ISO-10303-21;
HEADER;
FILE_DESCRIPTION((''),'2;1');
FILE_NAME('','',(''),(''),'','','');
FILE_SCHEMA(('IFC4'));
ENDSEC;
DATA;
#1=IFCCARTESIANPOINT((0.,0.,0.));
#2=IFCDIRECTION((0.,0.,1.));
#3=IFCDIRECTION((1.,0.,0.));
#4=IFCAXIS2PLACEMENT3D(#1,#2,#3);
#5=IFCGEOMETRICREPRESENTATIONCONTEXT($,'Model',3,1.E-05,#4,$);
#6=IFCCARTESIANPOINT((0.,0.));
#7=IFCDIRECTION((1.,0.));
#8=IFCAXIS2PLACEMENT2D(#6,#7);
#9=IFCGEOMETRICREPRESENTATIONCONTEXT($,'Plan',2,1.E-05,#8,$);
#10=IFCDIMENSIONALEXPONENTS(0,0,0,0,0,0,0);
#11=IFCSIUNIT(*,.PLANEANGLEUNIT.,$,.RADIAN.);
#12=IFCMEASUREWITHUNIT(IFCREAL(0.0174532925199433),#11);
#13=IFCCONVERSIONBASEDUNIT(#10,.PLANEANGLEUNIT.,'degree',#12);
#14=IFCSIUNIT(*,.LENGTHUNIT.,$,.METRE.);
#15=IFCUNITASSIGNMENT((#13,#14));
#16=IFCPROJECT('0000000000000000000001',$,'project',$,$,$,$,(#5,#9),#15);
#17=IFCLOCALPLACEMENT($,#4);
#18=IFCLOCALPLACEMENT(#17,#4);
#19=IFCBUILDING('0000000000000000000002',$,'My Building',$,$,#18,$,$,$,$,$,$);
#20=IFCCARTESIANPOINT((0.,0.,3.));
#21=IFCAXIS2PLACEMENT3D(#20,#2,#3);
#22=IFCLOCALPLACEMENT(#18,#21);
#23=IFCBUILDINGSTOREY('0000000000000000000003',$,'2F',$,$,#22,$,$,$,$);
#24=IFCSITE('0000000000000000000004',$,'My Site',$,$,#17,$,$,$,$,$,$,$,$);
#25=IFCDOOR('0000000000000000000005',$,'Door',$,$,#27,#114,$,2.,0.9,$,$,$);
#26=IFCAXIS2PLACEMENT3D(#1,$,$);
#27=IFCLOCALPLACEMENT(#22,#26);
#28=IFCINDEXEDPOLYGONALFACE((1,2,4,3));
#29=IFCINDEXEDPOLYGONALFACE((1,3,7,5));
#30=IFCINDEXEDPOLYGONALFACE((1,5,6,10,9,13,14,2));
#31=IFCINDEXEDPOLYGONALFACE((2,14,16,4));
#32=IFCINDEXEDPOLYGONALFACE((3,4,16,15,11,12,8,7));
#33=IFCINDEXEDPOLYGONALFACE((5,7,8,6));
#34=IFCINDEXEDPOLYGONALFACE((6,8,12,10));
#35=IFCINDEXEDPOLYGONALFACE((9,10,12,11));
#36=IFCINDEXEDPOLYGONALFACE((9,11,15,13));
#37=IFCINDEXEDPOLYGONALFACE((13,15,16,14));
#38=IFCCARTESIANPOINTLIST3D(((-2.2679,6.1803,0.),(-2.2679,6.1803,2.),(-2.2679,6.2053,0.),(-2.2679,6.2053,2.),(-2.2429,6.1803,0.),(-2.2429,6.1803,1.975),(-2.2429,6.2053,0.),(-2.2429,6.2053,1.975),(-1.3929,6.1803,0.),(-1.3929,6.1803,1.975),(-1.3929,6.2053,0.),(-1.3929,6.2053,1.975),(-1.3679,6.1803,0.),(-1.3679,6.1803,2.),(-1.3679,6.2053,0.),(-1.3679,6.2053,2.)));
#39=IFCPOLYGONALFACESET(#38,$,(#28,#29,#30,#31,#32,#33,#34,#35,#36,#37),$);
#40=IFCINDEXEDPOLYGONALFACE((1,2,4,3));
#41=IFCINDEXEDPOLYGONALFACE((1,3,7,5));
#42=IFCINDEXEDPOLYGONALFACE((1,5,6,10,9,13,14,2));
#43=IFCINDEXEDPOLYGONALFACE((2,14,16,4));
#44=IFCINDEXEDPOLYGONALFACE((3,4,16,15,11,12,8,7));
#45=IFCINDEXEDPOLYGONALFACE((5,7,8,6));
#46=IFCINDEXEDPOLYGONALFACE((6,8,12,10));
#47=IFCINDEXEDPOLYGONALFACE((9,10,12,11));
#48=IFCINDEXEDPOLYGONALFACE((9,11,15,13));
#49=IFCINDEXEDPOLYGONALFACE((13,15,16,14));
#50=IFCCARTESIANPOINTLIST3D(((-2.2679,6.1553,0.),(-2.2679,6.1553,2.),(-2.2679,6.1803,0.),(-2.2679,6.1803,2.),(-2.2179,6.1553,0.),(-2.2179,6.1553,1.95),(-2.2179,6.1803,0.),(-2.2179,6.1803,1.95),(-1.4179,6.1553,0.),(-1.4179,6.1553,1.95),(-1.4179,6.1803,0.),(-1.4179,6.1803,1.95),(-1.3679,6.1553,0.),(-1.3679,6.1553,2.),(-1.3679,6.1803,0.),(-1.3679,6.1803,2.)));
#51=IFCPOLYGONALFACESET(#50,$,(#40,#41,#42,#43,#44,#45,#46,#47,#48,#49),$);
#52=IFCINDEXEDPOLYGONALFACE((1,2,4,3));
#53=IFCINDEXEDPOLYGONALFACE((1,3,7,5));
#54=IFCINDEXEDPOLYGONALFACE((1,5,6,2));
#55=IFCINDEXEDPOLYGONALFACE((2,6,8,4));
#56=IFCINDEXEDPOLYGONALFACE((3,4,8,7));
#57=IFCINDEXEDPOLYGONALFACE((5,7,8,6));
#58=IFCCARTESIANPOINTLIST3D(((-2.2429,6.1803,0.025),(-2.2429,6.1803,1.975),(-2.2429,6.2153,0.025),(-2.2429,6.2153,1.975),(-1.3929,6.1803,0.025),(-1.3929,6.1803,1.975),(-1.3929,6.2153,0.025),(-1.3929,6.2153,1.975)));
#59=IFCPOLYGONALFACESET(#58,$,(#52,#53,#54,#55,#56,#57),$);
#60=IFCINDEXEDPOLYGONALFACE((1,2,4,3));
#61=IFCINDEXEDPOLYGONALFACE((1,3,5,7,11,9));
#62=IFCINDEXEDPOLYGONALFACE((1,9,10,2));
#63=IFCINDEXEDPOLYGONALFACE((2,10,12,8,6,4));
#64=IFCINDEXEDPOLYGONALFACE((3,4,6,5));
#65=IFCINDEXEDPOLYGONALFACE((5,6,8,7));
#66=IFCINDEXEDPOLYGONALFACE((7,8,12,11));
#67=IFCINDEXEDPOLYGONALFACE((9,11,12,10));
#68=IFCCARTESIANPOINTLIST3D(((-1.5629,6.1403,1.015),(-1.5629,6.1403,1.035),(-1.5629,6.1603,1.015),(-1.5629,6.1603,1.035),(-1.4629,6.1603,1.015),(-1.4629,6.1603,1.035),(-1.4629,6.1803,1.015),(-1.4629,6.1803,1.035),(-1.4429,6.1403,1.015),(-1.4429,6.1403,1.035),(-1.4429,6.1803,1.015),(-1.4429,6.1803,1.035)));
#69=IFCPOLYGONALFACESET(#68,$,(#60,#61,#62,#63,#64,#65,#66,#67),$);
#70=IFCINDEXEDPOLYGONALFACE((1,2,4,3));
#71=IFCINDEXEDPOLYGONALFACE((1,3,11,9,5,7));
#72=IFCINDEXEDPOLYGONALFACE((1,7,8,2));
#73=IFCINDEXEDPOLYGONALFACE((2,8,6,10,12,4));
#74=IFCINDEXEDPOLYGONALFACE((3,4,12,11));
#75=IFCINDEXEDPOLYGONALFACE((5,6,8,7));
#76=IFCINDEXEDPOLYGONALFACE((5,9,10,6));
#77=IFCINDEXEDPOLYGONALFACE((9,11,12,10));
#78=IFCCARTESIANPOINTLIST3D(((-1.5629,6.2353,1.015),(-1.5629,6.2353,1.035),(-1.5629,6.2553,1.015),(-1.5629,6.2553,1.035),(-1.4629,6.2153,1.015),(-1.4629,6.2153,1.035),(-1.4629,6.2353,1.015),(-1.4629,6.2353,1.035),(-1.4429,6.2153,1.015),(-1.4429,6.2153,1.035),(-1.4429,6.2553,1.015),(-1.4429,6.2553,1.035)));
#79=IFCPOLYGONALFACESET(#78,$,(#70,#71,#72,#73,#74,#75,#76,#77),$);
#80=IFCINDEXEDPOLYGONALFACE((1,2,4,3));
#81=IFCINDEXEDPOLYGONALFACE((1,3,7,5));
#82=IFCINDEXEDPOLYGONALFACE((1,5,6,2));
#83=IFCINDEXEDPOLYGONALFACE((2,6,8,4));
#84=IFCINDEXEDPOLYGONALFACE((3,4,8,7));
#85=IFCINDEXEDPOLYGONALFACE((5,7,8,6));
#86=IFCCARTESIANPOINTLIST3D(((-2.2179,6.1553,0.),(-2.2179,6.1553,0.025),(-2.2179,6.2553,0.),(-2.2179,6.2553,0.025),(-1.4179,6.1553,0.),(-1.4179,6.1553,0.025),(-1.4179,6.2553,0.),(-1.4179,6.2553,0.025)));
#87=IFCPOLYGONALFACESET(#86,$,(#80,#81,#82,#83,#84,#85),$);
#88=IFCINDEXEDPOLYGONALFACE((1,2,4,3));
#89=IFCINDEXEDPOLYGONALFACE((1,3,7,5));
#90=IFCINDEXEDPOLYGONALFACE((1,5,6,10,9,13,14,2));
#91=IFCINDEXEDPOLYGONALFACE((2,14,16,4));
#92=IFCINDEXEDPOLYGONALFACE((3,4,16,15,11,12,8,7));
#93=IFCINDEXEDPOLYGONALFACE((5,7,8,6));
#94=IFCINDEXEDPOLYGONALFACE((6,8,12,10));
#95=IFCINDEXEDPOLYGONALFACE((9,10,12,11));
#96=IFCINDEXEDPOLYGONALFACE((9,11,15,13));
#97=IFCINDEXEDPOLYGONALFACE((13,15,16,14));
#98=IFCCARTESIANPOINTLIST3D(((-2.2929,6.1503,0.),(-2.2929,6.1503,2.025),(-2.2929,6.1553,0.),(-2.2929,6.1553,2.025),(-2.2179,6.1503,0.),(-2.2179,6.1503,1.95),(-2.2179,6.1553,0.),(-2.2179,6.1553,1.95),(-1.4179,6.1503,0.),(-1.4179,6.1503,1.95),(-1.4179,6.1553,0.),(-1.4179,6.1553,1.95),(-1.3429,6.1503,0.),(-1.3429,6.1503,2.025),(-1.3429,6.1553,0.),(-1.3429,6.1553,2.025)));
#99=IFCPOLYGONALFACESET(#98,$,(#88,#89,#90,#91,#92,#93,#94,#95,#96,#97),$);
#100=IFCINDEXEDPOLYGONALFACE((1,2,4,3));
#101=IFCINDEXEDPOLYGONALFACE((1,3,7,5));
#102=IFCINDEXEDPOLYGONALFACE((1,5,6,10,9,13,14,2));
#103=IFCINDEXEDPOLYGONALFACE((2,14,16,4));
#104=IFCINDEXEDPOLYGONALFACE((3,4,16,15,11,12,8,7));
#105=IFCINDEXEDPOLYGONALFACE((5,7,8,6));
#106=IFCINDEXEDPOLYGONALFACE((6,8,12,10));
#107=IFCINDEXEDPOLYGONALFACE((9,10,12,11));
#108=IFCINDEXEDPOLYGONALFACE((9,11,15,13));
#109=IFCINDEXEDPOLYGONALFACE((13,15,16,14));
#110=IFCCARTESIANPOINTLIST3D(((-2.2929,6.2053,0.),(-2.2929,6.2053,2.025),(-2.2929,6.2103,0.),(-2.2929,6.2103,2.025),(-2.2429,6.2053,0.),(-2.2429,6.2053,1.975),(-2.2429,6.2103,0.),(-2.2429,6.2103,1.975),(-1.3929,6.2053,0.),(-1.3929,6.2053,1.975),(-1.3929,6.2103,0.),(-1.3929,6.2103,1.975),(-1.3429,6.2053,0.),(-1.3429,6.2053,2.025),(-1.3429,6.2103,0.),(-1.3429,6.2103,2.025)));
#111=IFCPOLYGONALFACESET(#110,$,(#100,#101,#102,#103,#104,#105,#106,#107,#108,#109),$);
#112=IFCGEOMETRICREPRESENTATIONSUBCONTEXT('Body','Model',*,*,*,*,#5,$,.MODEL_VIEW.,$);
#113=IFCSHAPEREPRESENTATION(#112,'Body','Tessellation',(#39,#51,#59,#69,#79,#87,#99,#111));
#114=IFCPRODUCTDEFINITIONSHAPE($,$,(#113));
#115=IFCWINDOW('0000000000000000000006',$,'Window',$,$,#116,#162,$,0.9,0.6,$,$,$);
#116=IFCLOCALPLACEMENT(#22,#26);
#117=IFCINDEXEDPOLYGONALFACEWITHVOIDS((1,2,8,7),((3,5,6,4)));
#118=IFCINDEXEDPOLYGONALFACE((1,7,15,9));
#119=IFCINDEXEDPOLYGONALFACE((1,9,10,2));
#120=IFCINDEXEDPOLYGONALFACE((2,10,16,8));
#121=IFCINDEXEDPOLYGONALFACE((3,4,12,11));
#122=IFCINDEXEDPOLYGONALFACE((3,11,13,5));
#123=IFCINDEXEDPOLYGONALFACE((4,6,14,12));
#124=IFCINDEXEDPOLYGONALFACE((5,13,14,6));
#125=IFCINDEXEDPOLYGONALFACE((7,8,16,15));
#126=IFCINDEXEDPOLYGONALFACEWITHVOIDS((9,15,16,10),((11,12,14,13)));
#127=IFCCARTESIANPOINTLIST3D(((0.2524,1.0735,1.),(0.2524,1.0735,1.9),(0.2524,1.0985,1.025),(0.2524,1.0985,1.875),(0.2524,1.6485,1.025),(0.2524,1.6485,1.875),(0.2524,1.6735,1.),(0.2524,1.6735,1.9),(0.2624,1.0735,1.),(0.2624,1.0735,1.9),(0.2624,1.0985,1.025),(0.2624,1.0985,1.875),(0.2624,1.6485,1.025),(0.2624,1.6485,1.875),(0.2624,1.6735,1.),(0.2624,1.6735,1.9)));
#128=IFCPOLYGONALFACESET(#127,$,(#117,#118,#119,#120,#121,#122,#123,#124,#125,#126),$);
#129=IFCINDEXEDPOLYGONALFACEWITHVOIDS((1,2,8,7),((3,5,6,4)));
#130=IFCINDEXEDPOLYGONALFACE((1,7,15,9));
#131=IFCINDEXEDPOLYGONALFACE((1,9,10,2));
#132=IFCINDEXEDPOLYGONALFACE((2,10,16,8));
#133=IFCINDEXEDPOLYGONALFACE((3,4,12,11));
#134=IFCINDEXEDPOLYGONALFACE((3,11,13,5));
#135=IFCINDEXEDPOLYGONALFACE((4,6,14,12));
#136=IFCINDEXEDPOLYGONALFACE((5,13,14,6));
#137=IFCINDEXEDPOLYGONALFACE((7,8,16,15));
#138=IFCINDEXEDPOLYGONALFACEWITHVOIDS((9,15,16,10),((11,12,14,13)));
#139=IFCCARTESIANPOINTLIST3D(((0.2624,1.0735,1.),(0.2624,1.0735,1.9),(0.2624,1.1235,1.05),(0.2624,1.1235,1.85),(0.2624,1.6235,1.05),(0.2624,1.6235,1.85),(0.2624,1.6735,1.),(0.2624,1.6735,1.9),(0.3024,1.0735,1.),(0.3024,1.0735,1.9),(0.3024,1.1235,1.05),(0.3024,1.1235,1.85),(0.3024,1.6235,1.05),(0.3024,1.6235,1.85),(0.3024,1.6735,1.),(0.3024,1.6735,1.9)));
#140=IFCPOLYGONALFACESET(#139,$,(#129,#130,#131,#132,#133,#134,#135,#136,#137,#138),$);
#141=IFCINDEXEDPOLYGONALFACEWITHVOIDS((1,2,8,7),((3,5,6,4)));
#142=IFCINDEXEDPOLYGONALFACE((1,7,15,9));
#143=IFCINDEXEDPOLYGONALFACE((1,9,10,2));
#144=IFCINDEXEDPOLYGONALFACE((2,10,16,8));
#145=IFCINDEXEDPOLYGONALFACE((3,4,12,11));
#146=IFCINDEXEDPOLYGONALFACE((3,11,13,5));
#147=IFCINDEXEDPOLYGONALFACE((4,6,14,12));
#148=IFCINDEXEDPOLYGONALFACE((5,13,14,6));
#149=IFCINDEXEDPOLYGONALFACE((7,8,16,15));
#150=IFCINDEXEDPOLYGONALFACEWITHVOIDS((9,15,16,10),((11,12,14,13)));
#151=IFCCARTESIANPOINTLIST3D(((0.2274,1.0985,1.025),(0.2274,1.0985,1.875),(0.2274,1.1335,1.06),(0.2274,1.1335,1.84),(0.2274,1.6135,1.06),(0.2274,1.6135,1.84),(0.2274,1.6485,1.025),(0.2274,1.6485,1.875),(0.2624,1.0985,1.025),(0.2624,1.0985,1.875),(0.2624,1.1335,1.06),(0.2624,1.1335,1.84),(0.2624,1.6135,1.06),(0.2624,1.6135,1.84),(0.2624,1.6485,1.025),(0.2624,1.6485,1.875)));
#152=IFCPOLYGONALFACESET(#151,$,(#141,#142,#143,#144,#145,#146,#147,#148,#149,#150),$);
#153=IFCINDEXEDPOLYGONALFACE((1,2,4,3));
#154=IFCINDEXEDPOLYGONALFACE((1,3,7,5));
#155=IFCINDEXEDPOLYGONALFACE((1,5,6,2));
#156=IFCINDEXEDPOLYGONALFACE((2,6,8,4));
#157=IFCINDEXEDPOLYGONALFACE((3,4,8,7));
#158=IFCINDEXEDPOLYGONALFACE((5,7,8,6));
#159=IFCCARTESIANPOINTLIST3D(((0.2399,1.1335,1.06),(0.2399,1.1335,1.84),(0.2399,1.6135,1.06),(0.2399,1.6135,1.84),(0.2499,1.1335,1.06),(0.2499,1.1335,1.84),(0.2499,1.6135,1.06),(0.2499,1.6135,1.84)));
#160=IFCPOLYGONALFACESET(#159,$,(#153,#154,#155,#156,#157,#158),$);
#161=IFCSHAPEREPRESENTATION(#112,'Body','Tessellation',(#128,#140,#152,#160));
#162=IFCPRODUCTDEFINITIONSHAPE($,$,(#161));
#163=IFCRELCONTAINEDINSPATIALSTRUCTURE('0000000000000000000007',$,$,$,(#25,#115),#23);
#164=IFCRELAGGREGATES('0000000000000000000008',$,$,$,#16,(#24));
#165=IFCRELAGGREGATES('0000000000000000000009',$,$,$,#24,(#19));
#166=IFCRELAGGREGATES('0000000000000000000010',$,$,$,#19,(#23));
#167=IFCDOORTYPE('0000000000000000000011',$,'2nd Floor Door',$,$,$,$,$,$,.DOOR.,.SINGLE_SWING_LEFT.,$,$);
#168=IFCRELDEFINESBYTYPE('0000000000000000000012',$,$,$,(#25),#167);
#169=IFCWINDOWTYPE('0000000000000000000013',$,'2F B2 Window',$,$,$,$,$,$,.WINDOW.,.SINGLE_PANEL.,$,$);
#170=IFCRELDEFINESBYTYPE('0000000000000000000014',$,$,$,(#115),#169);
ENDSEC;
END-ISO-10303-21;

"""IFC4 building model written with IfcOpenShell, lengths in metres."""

from ifc_helpers import new_model, entity, si_unit, converted_unit, frame, origin_with_axes, origin_2d_with_axis, place, context, subcontext, project, spatial, line, indexed_curve, outline, extrude, shape, source, transform, mapped, type_object, type_shapes, element, save


model = new_model("IFC4")

# Units and contexts
model_context = context("Model", 3, precision=1e-05, world=origin_with_axes())
plan_context = context("Plan", 2, precision=1e-05, world=origin_2d_with_axis())
body_context_1 = subcontext(model_context, "Body", "Model", "MODEL_VIEW")
body_context_2 = subcontext(plan_context, "Body", "Plan", "PLAN_VIEW")
ifc_project = project(units=[converted_unit("PLANEANGLEUNIT", "degree", entity("IfcReal", 0.0174532925199433), si_unit("PLANEANGLEUNIT", "RADIAN"), dimensions=[0, 0, 0, 0, 0, 0, 0]), si_unit("LENGTHUNIT", "METRE")], contexts=[model_context, plan_context])

# Site, building, storey
site_placement = place(None, origin_with_axes())
site = spatial("IfcSite", under=ifc_project, at=site_placement, Name="My Site")
building_placement = place(site_placement, origin_with_axes())
building = spatial("IfcBuilding", under=site, at=building_placement, Name="My Building")
storey_placement = place(building_placement, frame((0.0, 0.0, 3.0), z_axis=(0.0, 0.0, 1.0), x_axis=(1.0, 0.0, 0.0)))
storey = spatial("IfcBuildingStorey", under=building, at=storey_placement, Name="2F")

# Shared definitions
window_type_1 = type_object("IfcWindowType", Name="2F B2 Window", PartitioningType="SINGLE_PANEL", PredefinedType="WINDOW")
shared_shape_1 = source(origin_with_axes(), body_context_1, "Body", "SweptSolid", [
    extrude(outline(indexed_curve([(0.0, 0.0), (0.6, 0.0), (0.6, 0.9), (0.0, 0.9)], segments=[line(1, 2, 3, 4, 1)]), holes=[indexed_curve([(0.025, 0.025), (0.575, 0.025), (0.575, 0.875), (0.025, 0.875)], segments=[line(1, 2, 3, 4, 1)])]), frame((0.0, 0.09, 0.0), z_axis=(0.0, -1.0, 0.0), x_axis=(1.0, 0.0, 0.0)), (0.0, 0.0, -1.0), 0.01),
    extrude(outline(indexed_curve([(0.0, 0.0), (0.6, 0.0), (0.6, 0.9), (0.0, 0.9)], segments=[line(1, 2, 3, 4, 1)]), holes=[indexed_curve([(0.05, 0.05), (0.55, 0.05), (0.55, 0.85), (0.05, 0.85)], segments=[line(1, 2, 3, 4, 1)])]), frame((0.0, 0.05, 0.0), z_axis=(0.0, -1.0, 0.0), x_axis=(1.0, 0.0, 0.0)), (0.0, 0.0, -1.0), 0.04),
    extrude(outline(indexed_curve([(0.0, 0.0), (0.55, 0.0), (0.55, 0.85), (0.0, 0.85)], segments=[line(1, 2, 3, 4, 1)]), holes=[indexed_curve([(0.035, 0.035), (0.515, 0.035), (0.515, 0.815), (0.035, 0.815)], segments=[line(1, 2, 3, 4, 1)])]), frame((0.025, 0.09, 0.025), z_axis=(0.0, -1.0, 0.0), x_axis=(1.0, 0.0, 0.0)), (0.0, 0.0, -1.0), 0.035),
    extrude(outline(indexed_curve([(0.035, 0.035), (0.515, 0.035), (0.515, 0.815), (0.035, 0.815)], segments=[line(1, 2, 3, 4, 1)])), frame((0.025, 0.1025, 0.025), z_axis=(0.0, -1.0, 0.0), x_axis=(1.0, 0.0, 0.0)), (0.0, 0.0, -1.0), 0.01),
])
shared_shape_2 = source(origin_with_axes(), body_context_2, "Body", "Curve2D", [
    entity("IfcIndexedPolyCurve", entity("IfcCartesianPointList2D", [[0.05, 0.05], [0.55, 0.05]])),
    entity("IfcIndexedPolyCurve", entity("IfcCartesianPointList2D", [[0.0, 0.1], [0.025, 0.1], [0.025, 0.09], [0.05, 0.09], [0.05, 0.05], [0.0, 0.05]]), [entity("IfcLineIndex", [1, 2, 3, 4, 5, 6, 1])]),
    entity("IfcIndexedPolyCurve", entity("IfcCartesianPointList2D", [[0.6, 0.1], [0.575, 0.1], [0.575, 0.09], [0.55, 0.09], [0.55, 0.05], [0.6, 0.05]]), [entity("IfcLineIndex", [1, 2, 3, 4, 5, 6, 1])]),
    entity("IfcIndexedPolyCurve", entity("IfcCartesianPointList2D", [[0.025, 0.09], [0.06, 0.09], [0.06, 0.125], [0.025, 0.125]]), [entity("IfcLineIndex", [1, 2, 3, 4, 1])]),
    entity("IfcIndexedPolyCurve", entity("IfcCartesianPointList2D", [[0.575, 0.09], [0.54, 0.09], [0.54, 0.125], [0.575, 0.125]]), [entity("IfcLineIndex", [1, 2, 3, 4, 1])]),
    entity("IfcIndexedPolyCurve", entity("IfcCartesianPointList2D", [[0.06, 0.09], [0.54, 0.09]])),
    entity("IfcIndexedPolyCurve", entity("IfcCartesianPointList2D", [[0.06, 0.125], [0.54, 0.125]])),
    entity("IfcIndexedPolyCurve", entity("IfcCartesianPointList2D", [[0.06, 0.1075], [0.54, 0.1075]])),
])
type_shapes(window_type_1, [shared_shape_1, shared_shape_2])

# Shared definitions
door_type = type_object("IfcDoorType", Name="2nd Floor Door", OperationType="SINGLE_SWING_LEFT", PredefinedType="DOOR")
shared_shape_3 = source(origin_with_axes(), body_context_1, "Body", "SweptSolid", [
    extrude(outline(indexed_curve([(0.0, 0.0), (0.0, 2.0), (0.9, 2.0), (0.9, 0.0), (0.875, 0.0), (0.875, 1.975), (0.025, 1.975), (0.025, 0.0)], segments=[line(1, 2, 3, 4, 5, 6, 7, 8, 1)])), frame((0.0, 0.025, 0.0), z_axis=(0.0, -1.0, 0.0), x_axis=(1.0, 0.0, 0.0)), (0.0, 0.0, -1.0), 0.025),
    extrude(outline(indexed_curve([(0.0, 0.0), (0.0, 2.0), (0.9, 2.0), (0.9, 0.0), (0.85, 0.0), (0.85, 1.95), (0.05, 1.95), (0.05, 0.0)], segments=[line(1, 2, 3, 4, 5, 6, 7, 8, 1)])), frame((0.0, 0.0, 0.0), z_axis=(0.0, -1.0, 0.0), x_axis=(1.0, 0.0, 0.0)), (0.0, 0.0, -1.0), 0.025),
    extrude(outline(indexed_curve([(0.0, 0.0), (0.85, 0.0), (0.85, 0.035), (0.0, 0.035)], segments=[line(1, 2, 3, 4, 1)])), frame((0.025, 0.025, 0.025), z_axis=(0.0, 0.0, 1.0), x_axis=(1.0, 0.0, 0.0)), (0.0, 0.0, 1.0), 1.95),
    extrude(outline(indexed_curve([(0.0, 0.0), (0.0, -0.04), (-0.12, -0.04), (-0.12, -0.02), (-0.02, -0.02), (-0.02, 0.0)], segments=[line(1, 2, 3, 4, 5, 6, 1)])), frame((0.825, 0.025, 1.015), z_axis=(0.0, 0.0, 1.0), x_axis=(1.0, 0.0, 0.0)), (0.0, 0.0, 1.0), 0.02),
    extrude(outline(indexed_curve([(0.0, 0.0), (0.0, 0.04), (-0.12, 0.04), (-0.12, 0.02), (-0.02, 0.02), (-0.02, 0.0)], segments=[line(1, 2, 3, 4, 5, 6, 1)])), frame((0.825, 0.06, 1.015), z_axis=(0.0, 0.0, 1.0), x_axis=(1.0, 0.0, 0.0)), (0.0, 0.0, 1.0), 0.02),
    extrude(outline(indexed_curve([(0.0, 0.0), (0.8, 0.0), (0.8, 0.1), (0.0, 0.1)], segments=[line(1, 2, 3, 4, 1)])), frame((0.05, 0.0, 0.0), z_axis=(0.0, 0.0, 1.0), x_axis=(1.0, 0.0, 0.0)), (0.0, 0.0, 1.0), 0.025),
    extrude(outline(indexed_curve([(0.0, 0.0), (0.0, 2.025), (0.95, 2.025), (0.95, 0.0), (0.875, 0.0), (0.875, 1.95), (0.075, 1.95), (0.075, 0.0)], segments=[line(1, 2, 3, 4, 5, 6, 7, 8, 1)])), frame((-0.025, -0.005, 0.0), z_axis=(0.0, -1.0, 0.0), x_axis=(1.0, 0.0, 0.0)), (0.0, 0.0, -1.0), 0.005),
    extrude(outline(indexed_curve([(0.0, 0.0), (0.0, 2.025), (0.95, 2.025), (0.95, 0.0), (0.9, 0.0), (0.9, 1.975), (0.05, 1.975), (0.05, 0.0)], segments=[line(1, 2, 3, 4, 5, 6, 7, 8, 1)])), frame((-0.025, 0.05, 0.0), z_axis=(0.0, -1.0, 0.0), x_axis=(1.0, 0.0, 0.0)), (0.0, 0.0, -1.0), 0.005),
])
shared_shape_4 = source(origin_with_axes(), body_context_2, "Body", "Curve2D", [
    entity("IfcIndexedPolyCurve", entity("IfcCartesianPointList2D", [[0.0, 0.0], [0.0, 0.05], [0.025, 0.05], [0.025, 0.025], [0.05, 0.025], [0.05, 0.0]]), [entity("IfcLineIndex", [1, 2, 3, 4, 5, 6, 1])]),
    entity("IfcIndexedPolyCurve", entity("IfcCartesianPointList2D", [[0.9, 0.0], [0.9, 0.05], [0.875, 0.05], [0.875, 0.025], [0.85, 0.025], [0.85, 0.0]]), [entity("IfcLineIndex", [1, 2, 3, 4, 5, 6, 1])]),
    entity("IfcTrimmedCurve", entity("IfcEllipse", entity("IfcAxis2Placement2D", entity("IfcCartesianPoint", [0.06, 0.05]), entity("IfcDirection", [1.0, 0.0])), 0.815, 0.85), [entity("IfcCartesianPoint", [0.875, 0.05])], [entity("IfcCartesianPoint", [0.06, 0.9])], True, "CARTESIAN"),
    entity("IfcIndexedPolyCurve", entity("IfcCartesianPointList2D", [[0.025, 0.05], [0.06, 0.05], [0.06, 0.9], [0.025, 0.9]]), [entity("IfcLineIndex", [1, 2, 3, 4, 1])]),
])
type_shapes(door_type, [shared_shape_3, shared_shape_4])

# Door
door_1_placement = place(storey_placement, frame((-2.2679, 6.1553, 0.0), z_axis=(0.0, 0.0, 1.0), x_axis=(1.0, 0.0, 0.0)))
element("IfcDoor", 1, at=door_1_placement, inside=storey, type_object=door_type, Name="Door", OverallHeight=2.0, OverallWidth=0.9, shapes=[
    shape(body_context_1, "Body", "MappedRepresentation", [mapped(shared_shape_3, transform((0.0, 0.0, 0.0), x_axis=(1.0, 0.0, 0.0), y_axis=(0.0, 1.0, 0.0), z_axis=(0.0, 0.0, 1.0), scale=1.0))]),
    shape(body_context_2, "Body", "MappedRepresentation", [mapped(shared_shape_4, transform((0.0, 0.0, 0.0), x_axis=(1.0, 0.0, 0.0), y_axis=(0.0, 1.0, 0.0), z_axis=(0.0, 0.0, 1.0), scale=1.0))]),
])

# Window
placement_1 = place(storey_placement, frame((0.3524, -1.4434, 0.0), z_axis=(0.0, 0.0, 1.0), x_axis=(0.0, 1.0, 0.0)))
placement_2 = place(placement_1, frame((2.5169, 0.0, 1.0), z_axis=(0.0, 0.0, 1.0), x_axis=(1.0, 0.0, 0.0)))
window_1_placement = place(placement_2, frame((0.0, 0.0, 0.0), z_axis=(0.0, 0.0, 1.0), x_axis=(1.0, 0.0, 0.0)))
element("IfcWindow", 2, at=window_1_placement, inside=storey, type_object=window_type_1, Name="Window", OverallHeight=0.9, OverallWidth=0.6, shapes=[
    shape(body_context_1, "Body", "MappedRepresentation", [mapped(shared_shape_1, transform((0.0, 0.0, 0.0), x_axis=(1.0, 0.0, 0.0), y_axis=(0.0, 1.0, 0.0), z_axis=(0.0, 0.0, 1.0), scale=1.0))]),
    shape(body_context_2, "Body", "MappedRepresentation", [mapped(shared_shape_2, transform((0.0, 0.0, 0.0), x_axis=(1.0, 0.0, 0.0), y_axis=(0.0, 1.0, 0.0), z_axis=(0.0, 0.0, 1.0), scale=1.0))]),
])

save(model, "model.ifc")
